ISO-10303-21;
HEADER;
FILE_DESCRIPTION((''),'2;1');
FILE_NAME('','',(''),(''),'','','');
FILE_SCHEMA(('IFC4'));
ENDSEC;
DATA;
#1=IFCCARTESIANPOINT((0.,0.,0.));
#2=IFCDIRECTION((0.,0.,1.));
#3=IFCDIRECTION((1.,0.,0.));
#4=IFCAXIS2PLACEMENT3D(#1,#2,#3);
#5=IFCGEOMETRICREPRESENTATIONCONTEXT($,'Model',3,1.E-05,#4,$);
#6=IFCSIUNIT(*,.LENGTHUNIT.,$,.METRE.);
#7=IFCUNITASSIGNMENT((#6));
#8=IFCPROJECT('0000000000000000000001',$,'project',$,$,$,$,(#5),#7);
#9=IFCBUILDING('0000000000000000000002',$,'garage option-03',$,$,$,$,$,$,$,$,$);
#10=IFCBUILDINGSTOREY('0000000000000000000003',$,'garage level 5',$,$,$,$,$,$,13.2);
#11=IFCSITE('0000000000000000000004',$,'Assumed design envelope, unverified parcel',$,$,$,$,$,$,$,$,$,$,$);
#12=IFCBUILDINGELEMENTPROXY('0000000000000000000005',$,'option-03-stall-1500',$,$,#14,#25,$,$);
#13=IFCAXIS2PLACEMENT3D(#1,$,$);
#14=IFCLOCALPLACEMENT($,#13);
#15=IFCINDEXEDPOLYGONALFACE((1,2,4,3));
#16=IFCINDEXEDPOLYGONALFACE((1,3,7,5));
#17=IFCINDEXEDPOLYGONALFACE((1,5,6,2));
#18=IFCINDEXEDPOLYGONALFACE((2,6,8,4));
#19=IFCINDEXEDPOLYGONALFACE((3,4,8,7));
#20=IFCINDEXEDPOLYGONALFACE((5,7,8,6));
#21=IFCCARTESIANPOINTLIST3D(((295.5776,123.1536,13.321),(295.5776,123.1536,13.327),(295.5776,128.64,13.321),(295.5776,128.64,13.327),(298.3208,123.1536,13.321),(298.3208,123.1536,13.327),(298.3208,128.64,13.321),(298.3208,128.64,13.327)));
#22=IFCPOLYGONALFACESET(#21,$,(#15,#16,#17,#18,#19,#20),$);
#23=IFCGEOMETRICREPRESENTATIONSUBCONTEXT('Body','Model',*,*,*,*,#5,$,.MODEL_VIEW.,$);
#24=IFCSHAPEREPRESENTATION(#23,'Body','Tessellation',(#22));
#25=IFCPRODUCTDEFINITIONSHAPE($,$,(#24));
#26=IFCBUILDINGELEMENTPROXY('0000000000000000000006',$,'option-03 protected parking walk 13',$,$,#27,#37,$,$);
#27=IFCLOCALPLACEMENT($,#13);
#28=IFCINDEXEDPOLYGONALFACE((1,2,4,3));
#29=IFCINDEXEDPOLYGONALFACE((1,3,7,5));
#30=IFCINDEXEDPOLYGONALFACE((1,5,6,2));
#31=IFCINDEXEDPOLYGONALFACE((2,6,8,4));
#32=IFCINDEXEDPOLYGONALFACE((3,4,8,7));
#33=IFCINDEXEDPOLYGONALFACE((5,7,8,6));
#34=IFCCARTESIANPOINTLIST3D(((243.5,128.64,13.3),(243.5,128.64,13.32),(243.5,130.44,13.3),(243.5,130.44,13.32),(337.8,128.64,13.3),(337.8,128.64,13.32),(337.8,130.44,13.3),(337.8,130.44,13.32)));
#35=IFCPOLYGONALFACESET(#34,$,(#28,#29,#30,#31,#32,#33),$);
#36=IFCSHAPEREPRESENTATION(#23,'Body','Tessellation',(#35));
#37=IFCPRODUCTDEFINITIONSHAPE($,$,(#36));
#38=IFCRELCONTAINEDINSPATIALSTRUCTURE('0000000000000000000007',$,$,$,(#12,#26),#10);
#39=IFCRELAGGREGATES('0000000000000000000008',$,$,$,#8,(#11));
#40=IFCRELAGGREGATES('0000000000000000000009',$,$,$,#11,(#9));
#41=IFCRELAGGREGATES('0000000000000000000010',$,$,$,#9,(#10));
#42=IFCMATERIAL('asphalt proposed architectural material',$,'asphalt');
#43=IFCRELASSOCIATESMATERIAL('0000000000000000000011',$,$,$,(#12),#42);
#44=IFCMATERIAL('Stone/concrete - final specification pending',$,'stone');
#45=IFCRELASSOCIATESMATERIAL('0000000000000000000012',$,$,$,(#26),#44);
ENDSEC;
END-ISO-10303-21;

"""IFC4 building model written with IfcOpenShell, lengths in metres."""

from ifc_helpers import new_model, si_unit, frame, origin_with_axes, place, context, subcontext, project, spatial, rectangle, extrude, material, element, save


model = new_model("IFC4")

# Units and contexts
model_context = context("Model", 3, precision=1e-05, world=origin_with_axes())
body_context = subcontext(model_context, "Body", "Model", "MODEL_VIEW")
ifc_project = project(units=[si_unit("LENGTHUNIT", "METRE")], contexts=[model_context])

# Site, building, storey
site = spatial("IfcSite", under=ifc_project, Name="Assumed design envelope, unverified parcel")
building = spatial("IfcBuilding", under=site, Name="garage option-03")
storey = spatial("IfcBuildingStorey", under=building, Name="garage level 5", Elevation=13.2)

# Building element proxies
ifc_material_1 = material(Name="asphalt proposed architectural material", Category="asphalt")
for number, where, z_axis, x_axis, name in (
    (1, (296.9492, 125.8968, 13.321), (0.0, 0.0, 1.0), (1.0, 0.0, 0.0), "option-03-stall-1500"),
):
    element("IfcBuildingElementProxy", number, at=place(None, frame(where, z_axis=z_axis, x_axis=x_axis)), inside=storey, material=ifc_material_1, Name=name, context=body_context, shape_type="SweptSolid", body=[
        extrude(rectangle(XDim=2.7432, YDim=5.4864), origin_with_axes(), (0.0, 0.0, 1.0), 0.006),
    ])
ifc_material_2 = material(Name="Stone/concrete - final specification pending", Category="stone")
proxy_placement = place(None, frame((290.65, 129.54, 13.3), z_axis=(0.0, 0.0, 1.0), x_axis=(1.0, 0.0, 0.0)))
element("IfcBuildingElementProxy", 2, at=proxy_placement, inside=storey, material=ifc_material_2, Name="option-03 protected parking walk 13", context=body_context, shape_type="SweptSolid", body=[
    extrude(rectangle(XDim=94.3, YDim=1.8), origin_with_axes(), (0.0, 0.0, 1.0), 0.02),
])

save(model, "model.ifc")
